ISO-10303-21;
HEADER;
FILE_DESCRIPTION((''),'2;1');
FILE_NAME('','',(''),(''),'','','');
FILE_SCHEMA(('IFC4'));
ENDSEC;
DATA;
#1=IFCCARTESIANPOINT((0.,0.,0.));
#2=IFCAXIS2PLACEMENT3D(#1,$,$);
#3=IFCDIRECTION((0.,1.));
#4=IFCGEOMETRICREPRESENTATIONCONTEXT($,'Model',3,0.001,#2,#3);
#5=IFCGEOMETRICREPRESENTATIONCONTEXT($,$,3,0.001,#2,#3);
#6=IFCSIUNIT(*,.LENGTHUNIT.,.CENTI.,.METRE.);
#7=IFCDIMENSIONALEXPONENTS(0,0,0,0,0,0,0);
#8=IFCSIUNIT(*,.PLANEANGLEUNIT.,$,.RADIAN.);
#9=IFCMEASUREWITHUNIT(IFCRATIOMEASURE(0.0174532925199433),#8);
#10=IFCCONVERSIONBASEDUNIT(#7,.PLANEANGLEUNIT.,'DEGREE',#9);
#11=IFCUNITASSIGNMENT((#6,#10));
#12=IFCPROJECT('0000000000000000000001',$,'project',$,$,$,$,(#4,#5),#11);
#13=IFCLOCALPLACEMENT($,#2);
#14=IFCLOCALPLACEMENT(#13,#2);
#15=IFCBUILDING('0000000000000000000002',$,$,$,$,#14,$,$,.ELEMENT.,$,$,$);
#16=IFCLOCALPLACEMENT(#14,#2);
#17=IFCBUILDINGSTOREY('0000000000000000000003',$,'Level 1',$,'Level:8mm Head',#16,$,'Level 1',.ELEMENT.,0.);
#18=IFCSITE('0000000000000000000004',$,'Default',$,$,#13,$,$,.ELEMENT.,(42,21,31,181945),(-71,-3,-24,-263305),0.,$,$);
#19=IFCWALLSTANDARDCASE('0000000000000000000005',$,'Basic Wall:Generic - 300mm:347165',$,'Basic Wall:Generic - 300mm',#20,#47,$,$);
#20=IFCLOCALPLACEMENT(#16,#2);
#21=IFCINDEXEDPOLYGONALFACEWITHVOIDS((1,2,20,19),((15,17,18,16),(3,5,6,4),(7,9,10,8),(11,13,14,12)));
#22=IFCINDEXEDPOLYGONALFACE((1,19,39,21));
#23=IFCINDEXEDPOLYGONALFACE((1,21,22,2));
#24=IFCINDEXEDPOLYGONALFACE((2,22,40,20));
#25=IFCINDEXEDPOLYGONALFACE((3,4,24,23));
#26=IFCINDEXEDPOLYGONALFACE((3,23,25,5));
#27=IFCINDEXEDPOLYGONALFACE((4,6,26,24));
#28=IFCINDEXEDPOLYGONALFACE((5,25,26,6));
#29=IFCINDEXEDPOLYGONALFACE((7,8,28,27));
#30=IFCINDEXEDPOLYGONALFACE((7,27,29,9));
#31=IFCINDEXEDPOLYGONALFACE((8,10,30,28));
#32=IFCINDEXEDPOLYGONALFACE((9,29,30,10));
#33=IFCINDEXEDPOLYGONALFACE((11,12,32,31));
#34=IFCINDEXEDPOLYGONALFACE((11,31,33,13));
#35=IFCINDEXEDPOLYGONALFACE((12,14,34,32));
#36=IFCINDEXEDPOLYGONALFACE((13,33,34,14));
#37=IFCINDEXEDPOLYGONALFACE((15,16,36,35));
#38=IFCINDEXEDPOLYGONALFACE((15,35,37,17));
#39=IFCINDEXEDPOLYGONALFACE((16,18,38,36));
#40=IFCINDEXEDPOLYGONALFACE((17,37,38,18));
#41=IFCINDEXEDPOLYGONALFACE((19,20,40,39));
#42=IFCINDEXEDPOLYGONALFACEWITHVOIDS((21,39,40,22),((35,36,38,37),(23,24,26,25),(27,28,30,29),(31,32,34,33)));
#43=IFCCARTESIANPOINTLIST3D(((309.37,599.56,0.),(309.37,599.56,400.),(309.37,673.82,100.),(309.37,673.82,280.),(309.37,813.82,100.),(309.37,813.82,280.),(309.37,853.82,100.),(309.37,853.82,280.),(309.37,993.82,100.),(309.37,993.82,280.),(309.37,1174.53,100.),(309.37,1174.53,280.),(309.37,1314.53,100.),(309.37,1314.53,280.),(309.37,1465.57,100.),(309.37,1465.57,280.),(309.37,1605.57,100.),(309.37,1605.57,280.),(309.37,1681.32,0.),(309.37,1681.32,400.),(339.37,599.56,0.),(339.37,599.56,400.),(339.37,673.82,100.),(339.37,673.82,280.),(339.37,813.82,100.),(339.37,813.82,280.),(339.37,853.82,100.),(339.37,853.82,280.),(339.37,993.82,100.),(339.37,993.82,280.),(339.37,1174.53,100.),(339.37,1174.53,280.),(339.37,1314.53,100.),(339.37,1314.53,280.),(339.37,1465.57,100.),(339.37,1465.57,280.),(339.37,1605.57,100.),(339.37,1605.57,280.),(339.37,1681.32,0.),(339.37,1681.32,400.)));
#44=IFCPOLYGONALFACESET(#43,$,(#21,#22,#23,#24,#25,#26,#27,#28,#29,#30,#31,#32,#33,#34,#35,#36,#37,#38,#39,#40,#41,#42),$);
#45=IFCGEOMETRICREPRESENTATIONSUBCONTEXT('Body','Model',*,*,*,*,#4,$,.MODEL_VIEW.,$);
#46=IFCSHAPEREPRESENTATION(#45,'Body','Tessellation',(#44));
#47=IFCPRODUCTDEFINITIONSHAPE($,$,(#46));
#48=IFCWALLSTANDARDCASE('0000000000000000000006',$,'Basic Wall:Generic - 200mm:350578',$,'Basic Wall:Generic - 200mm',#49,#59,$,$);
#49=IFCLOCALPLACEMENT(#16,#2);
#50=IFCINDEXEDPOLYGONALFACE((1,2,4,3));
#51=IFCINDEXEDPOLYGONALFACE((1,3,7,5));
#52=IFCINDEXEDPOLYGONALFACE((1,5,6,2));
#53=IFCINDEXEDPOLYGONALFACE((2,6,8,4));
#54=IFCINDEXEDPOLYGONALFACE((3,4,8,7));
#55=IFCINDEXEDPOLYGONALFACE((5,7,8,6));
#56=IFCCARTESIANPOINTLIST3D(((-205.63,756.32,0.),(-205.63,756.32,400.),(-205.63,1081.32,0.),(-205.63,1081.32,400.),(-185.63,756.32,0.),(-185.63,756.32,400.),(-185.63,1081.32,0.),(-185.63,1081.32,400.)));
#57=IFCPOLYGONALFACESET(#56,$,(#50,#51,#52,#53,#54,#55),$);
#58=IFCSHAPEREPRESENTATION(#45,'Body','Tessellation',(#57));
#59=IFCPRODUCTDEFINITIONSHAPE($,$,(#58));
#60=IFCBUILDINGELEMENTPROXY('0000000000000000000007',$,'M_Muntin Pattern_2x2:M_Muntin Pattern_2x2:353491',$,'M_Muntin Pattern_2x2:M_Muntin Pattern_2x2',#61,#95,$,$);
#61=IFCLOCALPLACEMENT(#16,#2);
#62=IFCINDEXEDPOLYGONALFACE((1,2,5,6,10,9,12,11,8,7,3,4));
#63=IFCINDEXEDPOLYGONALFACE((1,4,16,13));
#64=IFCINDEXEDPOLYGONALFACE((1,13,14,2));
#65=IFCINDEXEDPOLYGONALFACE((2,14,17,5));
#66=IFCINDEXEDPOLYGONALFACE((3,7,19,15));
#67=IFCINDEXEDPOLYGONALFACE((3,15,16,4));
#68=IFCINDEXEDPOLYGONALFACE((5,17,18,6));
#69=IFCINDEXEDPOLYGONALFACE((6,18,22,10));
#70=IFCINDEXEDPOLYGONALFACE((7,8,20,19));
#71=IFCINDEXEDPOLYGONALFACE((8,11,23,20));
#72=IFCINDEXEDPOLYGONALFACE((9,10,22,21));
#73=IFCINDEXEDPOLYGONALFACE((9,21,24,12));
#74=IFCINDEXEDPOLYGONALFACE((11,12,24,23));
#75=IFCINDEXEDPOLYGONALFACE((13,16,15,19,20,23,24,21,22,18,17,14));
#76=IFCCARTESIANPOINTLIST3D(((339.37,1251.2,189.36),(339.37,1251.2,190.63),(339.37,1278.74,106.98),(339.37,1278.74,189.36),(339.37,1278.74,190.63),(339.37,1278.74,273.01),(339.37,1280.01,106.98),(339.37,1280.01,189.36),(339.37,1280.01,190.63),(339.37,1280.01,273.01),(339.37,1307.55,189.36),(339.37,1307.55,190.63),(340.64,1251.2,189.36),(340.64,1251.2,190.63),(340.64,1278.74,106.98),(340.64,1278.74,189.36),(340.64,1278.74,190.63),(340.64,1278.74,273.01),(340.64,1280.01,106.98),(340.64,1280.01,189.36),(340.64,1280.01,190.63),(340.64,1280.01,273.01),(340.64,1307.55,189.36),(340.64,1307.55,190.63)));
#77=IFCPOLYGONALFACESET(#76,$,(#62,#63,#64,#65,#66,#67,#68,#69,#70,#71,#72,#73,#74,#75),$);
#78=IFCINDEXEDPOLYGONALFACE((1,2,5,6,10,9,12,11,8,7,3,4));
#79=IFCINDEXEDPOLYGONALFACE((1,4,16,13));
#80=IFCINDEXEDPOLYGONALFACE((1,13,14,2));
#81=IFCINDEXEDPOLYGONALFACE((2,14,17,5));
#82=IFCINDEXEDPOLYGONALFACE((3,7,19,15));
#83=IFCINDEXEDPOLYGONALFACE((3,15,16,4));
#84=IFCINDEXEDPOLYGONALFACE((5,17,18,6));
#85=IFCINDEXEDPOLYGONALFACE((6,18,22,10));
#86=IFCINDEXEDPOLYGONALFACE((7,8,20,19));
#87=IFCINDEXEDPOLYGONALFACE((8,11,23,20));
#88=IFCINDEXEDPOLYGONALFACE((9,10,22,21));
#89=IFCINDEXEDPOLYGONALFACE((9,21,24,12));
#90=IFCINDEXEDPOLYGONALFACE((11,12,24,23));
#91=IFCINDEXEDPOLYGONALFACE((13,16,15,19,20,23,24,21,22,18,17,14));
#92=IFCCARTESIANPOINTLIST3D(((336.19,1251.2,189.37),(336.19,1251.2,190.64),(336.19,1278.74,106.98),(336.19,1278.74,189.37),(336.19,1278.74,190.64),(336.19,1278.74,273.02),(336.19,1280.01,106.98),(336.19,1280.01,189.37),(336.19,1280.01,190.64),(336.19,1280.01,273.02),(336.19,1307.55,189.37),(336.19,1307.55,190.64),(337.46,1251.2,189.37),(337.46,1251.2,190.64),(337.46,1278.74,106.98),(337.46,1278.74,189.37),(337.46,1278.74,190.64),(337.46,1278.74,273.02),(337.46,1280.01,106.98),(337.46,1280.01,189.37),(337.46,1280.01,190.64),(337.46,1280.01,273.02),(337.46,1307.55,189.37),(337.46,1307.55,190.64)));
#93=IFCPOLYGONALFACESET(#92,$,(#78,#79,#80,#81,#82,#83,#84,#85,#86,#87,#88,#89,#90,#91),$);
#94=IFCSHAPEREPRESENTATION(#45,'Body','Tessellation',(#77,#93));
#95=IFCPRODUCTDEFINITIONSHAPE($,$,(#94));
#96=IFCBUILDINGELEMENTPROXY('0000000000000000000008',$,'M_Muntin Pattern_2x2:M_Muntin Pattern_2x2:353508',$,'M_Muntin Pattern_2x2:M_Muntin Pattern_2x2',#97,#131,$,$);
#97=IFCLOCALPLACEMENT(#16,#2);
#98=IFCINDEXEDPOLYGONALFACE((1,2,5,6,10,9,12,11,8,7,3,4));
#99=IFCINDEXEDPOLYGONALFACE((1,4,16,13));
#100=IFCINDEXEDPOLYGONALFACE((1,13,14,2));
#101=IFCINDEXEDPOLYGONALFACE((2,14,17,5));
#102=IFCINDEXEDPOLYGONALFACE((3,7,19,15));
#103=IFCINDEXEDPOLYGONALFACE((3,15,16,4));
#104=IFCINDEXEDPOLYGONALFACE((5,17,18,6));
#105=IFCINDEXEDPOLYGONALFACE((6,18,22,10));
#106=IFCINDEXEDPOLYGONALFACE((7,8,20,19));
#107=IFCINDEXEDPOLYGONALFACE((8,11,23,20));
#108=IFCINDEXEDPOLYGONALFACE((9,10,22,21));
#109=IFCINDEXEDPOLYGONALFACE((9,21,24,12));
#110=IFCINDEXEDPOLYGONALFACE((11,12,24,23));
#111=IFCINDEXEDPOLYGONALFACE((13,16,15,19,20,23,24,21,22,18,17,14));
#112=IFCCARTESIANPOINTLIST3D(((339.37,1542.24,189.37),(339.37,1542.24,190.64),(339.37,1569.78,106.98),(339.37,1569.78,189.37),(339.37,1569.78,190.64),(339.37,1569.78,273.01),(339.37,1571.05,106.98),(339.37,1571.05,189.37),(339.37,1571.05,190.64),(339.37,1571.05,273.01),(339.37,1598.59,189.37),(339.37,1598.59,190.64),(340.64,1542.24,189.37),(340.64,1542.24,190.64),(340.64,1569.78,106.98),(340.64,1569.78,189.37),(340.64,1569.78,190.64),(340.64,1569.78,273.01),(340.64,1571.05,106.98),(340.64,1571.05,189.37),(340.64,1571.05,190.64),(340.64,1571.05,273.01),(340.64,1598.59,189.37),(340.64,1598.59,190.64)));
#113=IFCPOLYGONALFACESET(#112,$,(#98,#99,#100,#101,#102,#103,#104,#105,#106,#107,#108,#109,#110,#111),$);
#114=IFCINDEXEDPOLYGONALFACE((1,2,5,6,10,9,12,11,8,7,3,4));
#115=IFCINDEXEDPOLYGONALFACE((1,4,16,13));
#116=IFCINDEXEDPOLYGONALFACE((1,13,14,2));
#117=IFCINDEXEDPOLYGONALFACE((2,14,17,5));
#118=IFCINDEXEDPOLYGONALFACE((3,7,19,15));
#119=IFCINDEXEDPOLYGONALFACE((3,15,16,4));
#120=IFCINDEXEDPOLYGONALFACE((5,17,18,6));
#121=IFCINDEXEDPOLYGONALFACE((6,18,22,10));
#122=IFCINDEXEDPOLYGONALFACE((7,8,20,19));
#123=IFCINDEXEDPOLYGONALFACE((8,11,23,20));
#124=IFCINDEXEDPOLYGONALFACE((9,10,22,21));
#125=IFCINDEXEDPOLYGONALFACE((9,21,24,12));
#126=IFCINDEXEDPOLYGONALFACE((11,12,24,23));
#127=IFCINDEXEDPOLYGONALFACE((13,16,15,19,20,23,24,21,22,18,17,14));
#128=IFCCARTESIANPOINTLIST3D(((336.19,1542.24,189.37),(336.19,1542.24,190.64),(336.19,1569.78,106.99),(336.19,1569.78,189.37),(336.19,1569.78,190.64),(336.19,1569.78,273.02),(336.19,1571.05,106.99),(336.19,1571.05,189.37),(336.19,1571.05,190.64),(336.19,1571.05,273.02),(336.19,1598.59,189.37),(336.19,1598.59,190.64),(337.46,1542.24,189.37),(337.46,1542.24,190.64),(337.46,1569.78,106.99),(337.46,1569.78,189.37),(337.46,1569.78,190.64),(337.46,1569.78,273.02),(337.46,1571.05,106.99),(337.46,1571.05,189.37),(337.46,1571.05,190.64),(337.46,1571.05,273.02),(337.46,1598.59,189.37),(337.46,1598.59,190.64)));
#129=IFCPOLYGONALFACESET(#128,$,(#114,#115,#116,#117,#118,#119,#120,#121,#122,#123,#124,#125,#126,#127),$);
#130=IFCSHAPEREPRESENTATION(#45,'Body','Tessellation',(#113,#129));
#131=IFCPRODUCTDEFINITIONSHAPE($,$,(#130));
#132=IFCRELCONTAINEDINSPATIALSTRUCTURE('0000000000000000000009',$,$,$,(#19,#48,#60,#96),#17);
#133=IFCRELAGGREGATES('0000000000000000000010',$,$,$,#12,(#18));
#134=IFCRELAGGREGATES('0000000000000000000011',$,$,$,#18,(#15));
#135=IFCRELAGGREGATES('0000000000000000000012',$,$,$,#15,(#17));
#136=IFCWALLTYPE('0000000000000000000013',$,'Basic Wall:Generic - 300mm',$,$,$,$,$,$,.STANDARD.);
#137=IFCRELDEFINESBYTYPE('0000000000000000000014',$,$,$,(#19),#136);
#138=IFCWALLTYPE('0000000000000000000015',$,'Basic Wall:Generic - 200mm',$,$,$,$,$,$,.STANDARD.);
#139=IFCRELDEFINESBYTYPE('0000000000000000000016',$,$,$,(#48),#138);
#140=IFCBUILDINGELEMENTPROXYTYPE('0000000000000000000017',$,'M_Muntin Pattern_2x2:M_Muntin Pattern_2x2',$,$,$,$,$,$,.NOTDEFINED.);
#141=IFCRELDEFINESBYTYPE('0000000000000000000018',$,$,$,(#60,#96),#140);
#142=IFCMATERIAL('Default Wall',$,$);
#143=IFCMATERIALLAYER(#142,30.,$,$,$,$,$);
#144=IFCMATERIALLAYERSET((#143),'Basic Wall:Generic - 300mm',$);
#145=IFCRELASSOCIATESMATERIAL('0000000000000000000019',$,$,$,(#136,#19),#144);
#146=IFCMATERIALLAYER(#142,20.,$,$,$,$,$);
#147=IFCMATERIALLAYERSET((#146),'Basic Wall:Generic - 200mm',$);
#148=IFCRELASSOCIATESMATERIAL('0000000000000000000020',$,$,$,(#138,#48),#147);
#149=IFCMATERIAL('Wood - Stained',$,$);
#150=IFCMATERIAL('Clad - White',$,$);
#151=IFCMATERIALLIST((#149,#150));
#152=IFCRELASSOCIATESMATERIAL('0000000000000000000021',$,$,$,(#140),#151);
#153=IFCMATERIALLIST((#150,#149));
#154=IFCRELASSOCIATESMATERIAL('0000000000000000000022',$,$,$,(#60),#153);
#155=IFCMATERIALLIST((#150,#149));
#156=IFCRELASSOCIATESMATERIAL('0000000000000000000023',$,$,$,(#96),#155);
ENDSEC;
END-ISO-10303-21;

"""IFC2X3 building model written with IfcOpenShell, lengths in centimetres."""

from ifc_helpers import new_model, entity, si_unit, converted_unit, direction, frame, frame_2d, origin, place, context, subcontext, project, spatial, polyline, rectangle, outline, extrude, source, transform, mapped, material, material_list, layer, layer_set, layer_usage, type_object, type_shapes, element, save


model = new_model("IFC2X3")

# Units and contexts
model_context = context("Model", 3, precision=0.001, world=origin(), true_north=direction((0.0, 1.0)))
context_of_model = context(None, 3, precision=0.001, world=origin(), true_north=direction((0.0, 1.0)))
body_context = subcontext(model_context, "Body", "Model", "MODEL_VIEW")
ifc_project = project(units=[si_unit("LENGTHUNIT", "METRE", prefix="CENTI"), converted_unit("PLANEANGLEUNIT", "DEGREE", entity("IfcRatioMeasure", 0.0174532925199433), si_unit("PLANEANGLEUNIT", "RADIAN"), dimensions=[0, 0, 0, 0, 0, 0, 0])], contexts=[model_context, context_of_model])

# Site, building, storey
site_placement = place(None, origin())
site = spatial("IfcSite", under=ifc_project, at=site_placement, Name="Default", CompositionType="ELEMENT", RefLatitude=(42, 21, 31, 181945), RefLongitude=(-71, -3, -24, -263305), RefElevation=0.0)
building_placement = place(site_placement, origin())
building = spatial("IfcBuilding", under=site, at=building_placement, CompositionType="ELEMENT")
storey_placement = place(building_placement, origin())
storey = spatial("IfcBuildingStorey", under=building, at=storey_placement, Name="Level 1", ObjectType="Level:8mm Head", LongName="Level 1", CompositionType="ELEMENT", Elevation=0.0)

# Wall, openings
ifc_material_1 = material(Name="Default Wall")
ifc_layer_1 = layer(ifc_material_1, 30.0)
ifc_layer_set_1 = layer_set([ifc_layer_1], Name="Basic Wall:Generic - 300mm")
ifc_layer_usage_1 = layer_usage(ifc_layer_set_1, "AXIS2", "NEGATIVE", 15.0)
wall_type_1 = type_object("IfcWallType", Name="Basic Wall:Generic - 300mm", PredefinedType="STANDARD", material=ifc_layer_set_1)
wall_1_placement = place(storey_placement, frame((324.37, 1681.32, 0.0), z_axis=(0.0, 0.0, 1.0), x_axis=(0.0, -1.0, 0.0)))
wall_1 = element("IfcWallStandardCase", 1, at=wall_1_placement, inside=storey, type_object=wall_type_1, material=ifc_layer_usage_1, Name="Basic Wall:Generic - 300mm:347165", ObjectType="Basic Wall:Generic - 300mm", context=body_context, shape_type="SweptSolid", body=[
    extrude(rectangle(XDim=1081.77, YDim=30.0, at=frame_2d((540.88, 0.0), x_axis=(-1.0, 0.0))), origin(), (0.0, 0.0, 1.0), 400.0),
])
opening_1_placement = place(wall_1_placement, frame((75.75, -15.0, 100.0)))
element("IfcOpeningElement", 2, at=opening_1_placement, cuts=wall_1, ObjectType="Opening", context=body_context, shape_type="SweptSolid", body=[
    extrude(rectangle(XDim=180.0, YDim=140.0, at=frame_2d((90.0, 70.0), x_axis=(-1.0, 0.0))), frame((0.0, 0.0, 0.0), z_axis=(0.0, 1.0, 0.0), x_axis=(0.0, 0.0, 1.0)), (0.0, 0.0, 1.0), 30.0),
])
opening_2_placement = place(wall_1_placement, frame((366.79, -15.0, 100.0)))
element("IfcOpeningElement", 3, at=opening_2_placement, cuts=wall_1, ObjectType="Opening", context=body_context, shape_type="SweptSolid", body=[
    extrude(rectangle(XDim=180.0, YDim=140.0, at=frame_2d((90.0, 70.0), x_axis=(-1.0, 0.0))), frame((0.0, 0.0, 0.0), z_axis=(0.0, 1.0, 0.0), x_axis=(0.0, 0.0, 1.0)), (0.0, 0.0, 1.0), 30.0),
])
opening_3_placement = place(wall_1_placement, frame((687.5, -15.0, 100.0)))
element("IfcOpeningElement", 4, at=opening_3_placement, cuts=wall_1, ObjectType="Opening", context=body_context, shape_type="SweptSolid", body=[
    extrude(rectangle(XDim=180.0, YDim=140.0, at=frame_2d((90.0, 70.0), x_axis=(-1.0, 0.0))), frame((0.0, 0.0, 0.0), z_axis=(0.0, 1.0, 0.0), x_axis=(0.0, 0.0, 1.0)), (0.0, 0.0, 1.0), 30.0),
])
opening_4_placement = place(wall_1_placement, frame((867.5, -15.0, 100.0)))
element("IfcOpeningElement", 5, at=opening_4_placement, cuts=wall_1, ObjectType="Opening", context=body_context, shape_type="SweptSolid", body=[
    extrude(rectangle(XDim=180.0, YDim=140.0, at=frame_2d((90.0, 70.0), x_axis=(-1.0, 0.0))), frame((0.0, 0.0, 0.0), z_axis=(0.0, 1.0, 0.0), x_axis=(0.0, 0.0, 1.0)), (0.0, 0.0, 1.0), 30.0),
])

# Wall
ifc_layer_2 = layer(ifc_material_1, 20.0)
ifc_layer_set_2 = layer_set([ifc_layer_2], Name="Basic Wall:Generic - 200mm")
ifc_layer_usage_2 = layer_usage(ifc_layer_set_2, "AXIS2", "NEGATIVE", 10.0)
wall_type_2 = type_object("IfcWallType", Name="Basic Wall:Generic - 200mm", PredefinedType="STANDARD", material=ifc_layer_set_2)
wall_2_placement = place(storey_placement, frame((-195.63, 1081.32, 0.0), z_axis=(0.0, 0.0, 1.0), x_axis=(0.0, -1.0, 0.0)))
element("IfcWallStandardCase", 6, at=wall_2_placement, inside=storey, type_object=wall_type_2, material=ifc_layer_usage_2, Name="Basic Wall:Generic - 200mm:350578", ObjectType="Basic Wall:Generic - 200mm", context=body_context, shape_type="SweptSolid", body=[
    extrude(rectangle(XDim=325.0, YDim=20.0, at=frame_2d((162.5, 0.0), x_axis=(-1.0, 0.0))), origin(), (0.0, 0.0, 1.0), 400.0),
])

# Building element proxies
ifc_material_2 = material(Name="Clad - White")
ifc_material_3 = material(Name="Wood - Stained")
ifc_material_list_1 = material_list([ifc_material_2, ifc_material_3])
ifc_material_list_2 = material_list([ifc_material_3, ifc_material_2])
building_element_proxy_type_1 = type_object("IfcBuildingElementProxyType", Name="M_Muntin Pattern_2x2:M_Muntin Pattern_2x2", PredefinedType="NOTDEFINED", material=ifc_material_list_2)
shared_shape_1 = source(origin(), body_context, "Body", "SweptSolid", [
    extrude(outline(polyline([(0.64, -0.64), (83.01, -0.64), (83.01, 0.63), (0.64, 0.63), (0.64, 28.17), (-0.63, 28.17), (-0.63, 0.63), (-83.02, 0.63), (-83.02, -0.64), (-0.63, -0.64), (-0.63, -28.17), (0.64, -28.17), (0.64, -0.64)])), frame((0.0, 0.95, 83.01), z_axis=(0.0, 1.0, 0.0), x_axis=(0.0, 0.0, 1.0)), (0.0, 0.0, 1.0), 1.27),
    extrude(outline(polyline([(0.64, -0.64), (83.02, -0.64), (83.02, 0.63), (0.64, 0.63), (0.64, 28.17), (-0.63, 28.17), (-0.63, 0.63), (-83.02, 0.63), (-83.02, -0.64), (-0.63, -0.64), (-0.63, -28.17), (0.64, -28.17), (0.64, -0.64)])), frame((0.0, -2.22, 83.02), z_axis=(0.0, 1.0, 0.0), x_axis=(0.0, 0.0, 1.0)), (0.0, 0.0, 1.0), 1.27),
])
type_shapes(building_element_proxy_type_1, [shared_shape_1])
proxy_1_placement = place(storey_placement, frame((338.41, 1279.37, 106.98), z_axis=(0.0, 0.0, 1.0), x_axis=(0.0, -1.0, 0.0)))
element("IfcBuildingElementProxy", 7, at=proxy_1_placement, inside=storey, type_object=building_element_proxy_type_1, material=ifc_material_list_1, Name="M_Muntin Pattern_2x2:M_Muntin Pattern_2x2:353491", ObjectType="M_Muntin Pattern_2x2:M_Muntin Pattern_2x2", context=body_context, shape_type="MappedRepresentation", body=[
    mapped(shared_shape_1, transform((0.0, 0.0, 0.0), scale=1.0)),
])
ifc_material_list_3 = material_list([ifc_material_2, ifc_material_3])
proxy_2_placement = place(storey_placement, frame((338.41, 1570.42, 106.99), z_axis=(0.0, 0.0, 1.0), x_axis=(0.0, -1.0, 0.0)))
element("IfcBuildingElementProxy", 8, at=proxy_2_placement, inside=storey, type_object=building_element_proxy_type_1, material=ifc_material_list_3, Name="M_Muntin Pattern_2x2:M_Muntin Pattern_2x2:353508", ObjectType="M_Muntin Pattern_2x2:M_Muntin Pattern_2x2", context=body_context, shape_type="MappedRepresentation", body=[
    mapped(shared_shape_1, transform((0.0, 0.0, 0.0), scale=1.0)),
])

save(model, "model.ifc")
